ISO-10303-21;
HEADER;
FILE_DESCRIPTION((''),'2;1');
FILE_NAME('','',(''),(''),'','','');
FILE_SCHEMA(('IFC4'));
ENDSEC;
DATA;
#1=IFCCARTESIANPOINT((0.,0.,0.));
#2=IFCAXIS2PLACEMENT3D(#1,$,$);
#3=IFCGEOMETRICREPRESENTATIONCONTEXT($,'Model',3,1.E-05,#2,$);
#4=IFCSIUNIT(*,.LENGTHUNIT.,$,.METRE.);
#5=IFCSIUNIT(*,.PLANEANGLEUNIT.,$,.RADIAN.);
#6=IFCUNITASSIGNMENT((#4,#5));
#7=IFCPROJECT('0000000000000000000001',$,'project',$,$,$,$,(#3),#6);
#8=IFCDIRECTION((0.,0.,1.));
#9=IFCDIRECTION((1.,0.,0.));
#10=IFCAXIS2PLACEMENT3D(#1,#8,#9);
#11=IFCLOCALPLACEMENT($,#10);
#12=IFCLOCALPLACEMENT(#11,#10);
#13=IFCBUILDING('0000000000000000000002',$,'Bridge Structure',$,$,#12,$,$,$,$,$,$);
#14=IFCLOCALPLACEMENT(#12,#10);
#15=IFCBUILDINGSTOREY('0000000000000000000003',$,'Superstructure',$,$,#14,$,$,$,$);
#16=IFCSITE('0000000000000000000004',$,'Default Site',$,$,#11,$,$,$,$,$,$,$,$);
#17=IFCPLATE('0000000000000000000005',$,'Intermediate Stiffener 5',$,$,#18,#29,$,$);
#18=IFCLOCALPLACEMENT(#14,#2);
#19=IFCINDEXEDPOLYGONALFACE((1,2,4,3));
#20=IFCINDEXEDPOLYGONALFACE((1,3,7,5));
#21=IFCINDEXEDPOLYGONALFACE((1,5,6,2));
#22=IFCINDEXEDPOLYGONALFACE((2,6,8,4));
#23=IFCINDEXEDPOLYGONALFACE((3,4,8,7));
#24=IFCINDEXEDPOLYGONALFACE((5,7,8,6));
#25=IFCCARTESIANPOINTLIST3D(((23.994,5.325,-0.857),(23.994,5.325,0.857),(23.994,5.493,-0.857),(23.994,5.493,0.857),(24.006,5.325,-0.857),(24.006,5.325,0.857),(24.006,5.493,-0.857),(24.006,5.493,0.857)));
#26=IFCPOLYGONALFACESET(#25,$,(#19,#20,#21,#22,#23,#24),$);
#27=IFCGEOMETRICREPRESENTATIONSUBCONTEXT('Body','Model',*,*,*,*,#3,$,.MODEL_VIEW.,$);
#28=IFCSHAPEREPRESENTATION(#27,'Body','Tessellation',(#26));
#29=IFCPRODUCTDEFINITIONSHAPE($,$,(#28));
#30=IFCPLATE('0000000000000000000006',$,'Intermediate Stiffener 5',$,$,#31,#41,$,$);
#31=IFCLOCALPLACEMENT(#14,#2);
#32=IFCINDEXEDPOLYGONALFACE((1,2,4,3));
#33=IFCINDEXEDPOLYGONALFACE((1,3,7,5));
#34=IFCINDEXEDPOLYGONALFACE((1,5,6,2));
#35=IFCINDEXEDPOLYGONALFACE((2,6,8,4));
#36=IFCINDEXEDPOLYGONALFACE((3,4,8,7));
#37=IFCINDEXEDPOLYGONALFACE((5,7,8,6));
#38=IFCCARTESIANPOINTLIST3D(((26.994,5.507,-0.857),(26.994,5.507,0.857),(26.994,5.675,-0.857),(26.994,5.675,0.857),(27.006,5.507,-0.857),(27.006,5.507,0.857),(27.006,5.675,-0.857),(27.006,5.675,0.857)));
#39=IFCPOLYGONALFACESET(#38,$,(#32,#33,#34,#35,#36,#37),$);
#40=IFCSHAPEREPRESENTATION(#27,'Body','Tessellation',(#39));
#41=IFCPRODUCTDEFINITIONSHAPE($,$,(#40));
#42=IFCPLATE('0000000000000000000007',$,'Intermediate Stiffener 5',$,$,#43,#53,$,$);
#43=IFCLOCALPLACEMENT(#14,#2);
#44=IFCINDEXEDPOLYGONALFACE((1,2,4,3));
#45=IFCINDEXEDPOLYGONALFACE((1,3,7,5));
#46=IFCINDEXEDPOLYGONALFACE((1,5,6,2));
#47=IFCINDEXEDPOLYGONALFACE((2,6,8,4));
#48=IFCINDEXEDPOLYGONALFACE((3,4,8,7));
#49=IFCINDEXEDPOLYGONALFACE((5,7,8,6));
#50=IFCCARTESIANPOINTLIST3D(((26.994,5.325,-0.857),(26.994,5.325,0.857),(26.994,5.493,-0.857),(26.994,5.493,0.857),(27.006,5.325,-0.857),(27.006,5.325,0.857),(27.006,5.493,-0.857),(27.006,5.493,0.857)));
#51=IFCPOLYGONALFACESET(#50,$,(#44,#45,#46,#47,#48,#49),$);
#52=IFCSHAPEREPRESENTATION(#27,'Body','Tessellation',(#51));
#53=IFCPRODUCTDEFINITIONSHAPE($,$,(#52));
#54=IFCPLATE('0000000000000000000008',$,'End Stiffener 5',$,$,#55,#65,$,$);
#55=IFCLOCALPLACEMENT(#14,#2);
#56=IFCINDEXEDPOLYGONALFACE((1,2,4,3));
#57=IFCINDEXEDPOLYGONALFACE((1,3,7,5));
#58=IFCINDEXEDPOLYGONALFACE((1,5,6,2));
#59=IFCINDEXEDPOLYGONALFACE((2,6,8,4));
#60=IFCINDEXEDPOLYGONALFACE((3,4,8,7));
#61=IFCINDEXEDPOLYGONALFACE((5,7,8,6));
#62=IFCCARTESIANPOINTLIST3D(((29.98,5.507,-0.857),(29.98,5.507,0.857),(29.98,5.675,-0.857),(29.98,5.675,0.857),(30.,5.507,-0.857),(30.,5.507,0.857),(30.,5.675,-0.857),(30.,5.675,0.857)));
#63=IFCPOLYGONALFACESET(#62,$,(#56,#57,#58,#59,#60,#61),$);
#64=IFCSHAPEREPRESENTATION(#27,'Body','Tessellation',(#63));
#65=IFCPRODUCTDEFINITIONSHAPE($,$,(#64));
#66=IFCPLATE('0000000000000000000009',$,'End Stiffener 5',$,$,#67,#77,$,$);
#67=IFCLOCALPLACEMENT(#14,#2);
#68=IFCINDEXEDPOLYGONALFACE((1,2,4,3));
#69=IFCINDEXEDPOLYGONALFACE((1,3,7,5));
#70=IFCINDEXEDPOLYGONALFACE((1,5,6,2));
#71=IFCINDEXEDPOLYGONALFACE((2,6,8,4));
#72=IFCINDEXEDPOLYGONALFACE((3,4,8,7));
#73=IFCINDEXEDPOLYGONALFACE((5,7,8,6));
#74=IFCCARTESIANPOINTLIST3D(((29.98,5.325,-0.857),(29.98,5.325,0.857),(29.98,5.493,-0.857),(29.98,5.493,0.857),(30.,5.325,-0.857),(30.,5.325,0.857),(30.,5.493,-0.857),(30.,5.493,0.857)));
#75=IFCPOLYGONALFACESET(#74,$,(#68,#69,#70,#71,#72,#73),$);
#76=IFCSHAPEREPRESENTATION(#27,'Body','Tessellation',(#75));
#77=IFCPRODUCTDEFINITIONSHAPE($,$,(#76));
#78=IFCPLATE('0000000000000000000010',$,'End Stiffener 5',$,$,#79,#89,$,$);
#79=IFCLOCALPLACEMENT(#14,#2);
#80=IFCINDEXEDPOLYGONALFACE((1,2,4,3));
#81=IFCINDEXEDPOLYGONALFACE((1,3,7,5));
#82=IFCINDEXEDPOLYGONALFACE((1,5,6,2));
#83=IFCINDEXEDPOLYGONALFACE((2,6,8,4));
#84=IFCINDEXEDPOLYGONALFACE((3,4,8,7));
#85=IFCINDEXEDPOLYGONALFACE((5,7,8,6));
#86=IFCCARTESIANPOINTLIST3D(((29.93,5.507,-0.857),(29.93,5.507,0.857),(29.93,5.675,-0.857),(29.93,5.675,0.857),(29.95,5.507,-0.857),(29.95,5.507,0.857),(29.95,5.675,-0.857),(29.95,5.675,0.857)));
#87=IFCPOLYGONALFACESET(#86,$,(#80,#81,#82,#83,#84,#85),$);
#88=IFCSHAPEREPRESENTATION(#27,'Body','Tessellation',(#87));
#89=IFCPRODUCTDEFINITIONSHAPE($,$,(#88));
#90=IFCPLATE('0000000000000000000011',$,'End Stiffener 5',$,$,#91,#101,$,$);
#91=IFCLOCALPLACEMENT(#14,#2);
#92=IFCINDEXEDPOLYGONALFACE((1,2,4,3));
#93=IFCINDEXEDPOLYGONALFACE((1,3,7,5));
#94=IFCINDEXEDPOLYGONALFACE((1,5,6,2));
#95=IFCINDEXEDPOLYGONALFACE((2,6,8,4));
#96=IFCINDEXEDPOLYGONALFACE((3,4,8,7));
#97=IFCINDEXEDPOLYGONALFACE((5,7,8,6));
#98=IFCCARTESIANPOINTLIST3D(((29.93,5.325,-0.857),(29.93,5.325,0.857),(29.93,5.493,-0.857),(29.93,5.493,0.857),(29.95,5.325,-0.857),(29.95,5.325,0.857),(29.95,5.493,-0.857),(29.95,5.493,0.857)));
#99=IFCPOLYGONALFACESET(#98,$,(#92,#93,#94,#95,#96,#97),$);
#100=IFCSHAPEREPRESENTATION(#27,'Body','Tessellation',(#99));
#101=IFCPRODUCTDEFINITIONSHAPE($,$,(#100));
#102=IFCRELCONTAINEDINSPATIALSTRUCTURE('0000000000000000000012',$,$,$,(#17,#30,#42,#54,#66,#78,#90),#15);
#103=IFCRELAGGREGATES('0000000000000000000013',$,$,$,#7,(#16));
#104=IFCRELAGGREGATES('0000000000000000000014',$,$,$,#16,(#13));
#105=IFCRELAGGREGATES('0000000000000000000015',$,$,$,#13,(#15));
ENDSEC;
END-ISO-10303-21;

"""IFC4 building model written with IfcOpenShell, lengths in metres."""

from ifc_helpers import new_model, si_unit, frame, origin, origin_with_axes, origin_2d_with_axis, place, context, subcontext, project, spatial, rectangle, extrude, element, save


model = new_model("IFC4")

# Units and contexts
model_context = context("Model", 3, precision=1e-05, world=origin())
body_context = subcontext(model_context, "Body", "Model", "MODEL_VIEW")
ifc_project = project(units=[si_unit("LENGTHUNIT", "METRE"), si_unit("PLANEANGLEUNIT", "RADIAN")], contexts=[model_context])

# Site, building, storey
site_placement = place(None, origin_with_axes())
site = spatial("IfcSite", under=ifc_project, at=site_placement, Name="Default Site")
building_placement = place(site_placement, origin_with_axes())
building = spatial("IfcBuilding", under=site, at=building_placement, Name="Bridge Structure")
storey_placement = place(building_placement, origin_with_axes())
storey = spatial("IfcBuildingStorey", under=building, at=storey_placement, Name="Superstructure")

# Plates
for number, where, z_axis, x_axis, name in (
    (1, (24.0, 5.409, -0.857), (0.0, 0.0, 1.0), (1.0, 0.0, 0.0), "Intermediate Stiffener 5"),
    (2, (27.0, 5.591, -0.857), (0.0, 0.0, 1.0), (1.0, 0.0, 0.0), "Intermediate Stiffener 5"),
    (3, (27.0, 5.409, -0.857), (0.0, 0.0, 1.0), (1.0, 0.0, 0.0), "Intermediate Stiffener 5"),
):
    element("IfcPlate", number, at=place(storey_placement, frame(where, z_axis=z_axis, x_axis=x_axis)), inside=storey, Name=name, context=body_context, shape_type="SweptSolid", body=[
        extrude(rectangle(XDim=0.012, YDim=0.168, at=origin_2d_with_axis()), origin_with_axes(), (0.0, 0.0, 1.0), 1.714),
    ])
for number, where, z_axis, x_axis, name in (
    (4, (29.99, 5.591, -0.857), (0.0, 0.0, 1.0), (1.0, 0.0, 0.0), "End Stiffener 5"),
    (5, (29.99, 5.409, -0.857), (0.0, 0.0, 1.0), (1.0, 0.0, 0.0), "End Stiffener 5"),
    (6, (29.94, 5.591, -0.857), (0.0, 0.0, 1.0), (1.0, 0.0, 0.0), "End Stiffener 5"),
    (7, (29.94, 5.409, -0.857), (0.0, 0.0, 1.0), (1.0, 0.0, 0.0), "End Stiffener 5"),
):
    element("IfcPlate", number, at=place(storey_placement, frame(where, z_axis=z_axis, x_axis=x_axis)), inside=storey, Name=name, context=body_context, shape_type="SweptSolid", body=[
        extrude(rectangle(XDim=0.02, YDim=0.168, at=origin_2d_with_axis()), origin_with_axes(), (0.0, 0.0, 1.0), 1.714),
    ])

save(model, "model.ifc")
